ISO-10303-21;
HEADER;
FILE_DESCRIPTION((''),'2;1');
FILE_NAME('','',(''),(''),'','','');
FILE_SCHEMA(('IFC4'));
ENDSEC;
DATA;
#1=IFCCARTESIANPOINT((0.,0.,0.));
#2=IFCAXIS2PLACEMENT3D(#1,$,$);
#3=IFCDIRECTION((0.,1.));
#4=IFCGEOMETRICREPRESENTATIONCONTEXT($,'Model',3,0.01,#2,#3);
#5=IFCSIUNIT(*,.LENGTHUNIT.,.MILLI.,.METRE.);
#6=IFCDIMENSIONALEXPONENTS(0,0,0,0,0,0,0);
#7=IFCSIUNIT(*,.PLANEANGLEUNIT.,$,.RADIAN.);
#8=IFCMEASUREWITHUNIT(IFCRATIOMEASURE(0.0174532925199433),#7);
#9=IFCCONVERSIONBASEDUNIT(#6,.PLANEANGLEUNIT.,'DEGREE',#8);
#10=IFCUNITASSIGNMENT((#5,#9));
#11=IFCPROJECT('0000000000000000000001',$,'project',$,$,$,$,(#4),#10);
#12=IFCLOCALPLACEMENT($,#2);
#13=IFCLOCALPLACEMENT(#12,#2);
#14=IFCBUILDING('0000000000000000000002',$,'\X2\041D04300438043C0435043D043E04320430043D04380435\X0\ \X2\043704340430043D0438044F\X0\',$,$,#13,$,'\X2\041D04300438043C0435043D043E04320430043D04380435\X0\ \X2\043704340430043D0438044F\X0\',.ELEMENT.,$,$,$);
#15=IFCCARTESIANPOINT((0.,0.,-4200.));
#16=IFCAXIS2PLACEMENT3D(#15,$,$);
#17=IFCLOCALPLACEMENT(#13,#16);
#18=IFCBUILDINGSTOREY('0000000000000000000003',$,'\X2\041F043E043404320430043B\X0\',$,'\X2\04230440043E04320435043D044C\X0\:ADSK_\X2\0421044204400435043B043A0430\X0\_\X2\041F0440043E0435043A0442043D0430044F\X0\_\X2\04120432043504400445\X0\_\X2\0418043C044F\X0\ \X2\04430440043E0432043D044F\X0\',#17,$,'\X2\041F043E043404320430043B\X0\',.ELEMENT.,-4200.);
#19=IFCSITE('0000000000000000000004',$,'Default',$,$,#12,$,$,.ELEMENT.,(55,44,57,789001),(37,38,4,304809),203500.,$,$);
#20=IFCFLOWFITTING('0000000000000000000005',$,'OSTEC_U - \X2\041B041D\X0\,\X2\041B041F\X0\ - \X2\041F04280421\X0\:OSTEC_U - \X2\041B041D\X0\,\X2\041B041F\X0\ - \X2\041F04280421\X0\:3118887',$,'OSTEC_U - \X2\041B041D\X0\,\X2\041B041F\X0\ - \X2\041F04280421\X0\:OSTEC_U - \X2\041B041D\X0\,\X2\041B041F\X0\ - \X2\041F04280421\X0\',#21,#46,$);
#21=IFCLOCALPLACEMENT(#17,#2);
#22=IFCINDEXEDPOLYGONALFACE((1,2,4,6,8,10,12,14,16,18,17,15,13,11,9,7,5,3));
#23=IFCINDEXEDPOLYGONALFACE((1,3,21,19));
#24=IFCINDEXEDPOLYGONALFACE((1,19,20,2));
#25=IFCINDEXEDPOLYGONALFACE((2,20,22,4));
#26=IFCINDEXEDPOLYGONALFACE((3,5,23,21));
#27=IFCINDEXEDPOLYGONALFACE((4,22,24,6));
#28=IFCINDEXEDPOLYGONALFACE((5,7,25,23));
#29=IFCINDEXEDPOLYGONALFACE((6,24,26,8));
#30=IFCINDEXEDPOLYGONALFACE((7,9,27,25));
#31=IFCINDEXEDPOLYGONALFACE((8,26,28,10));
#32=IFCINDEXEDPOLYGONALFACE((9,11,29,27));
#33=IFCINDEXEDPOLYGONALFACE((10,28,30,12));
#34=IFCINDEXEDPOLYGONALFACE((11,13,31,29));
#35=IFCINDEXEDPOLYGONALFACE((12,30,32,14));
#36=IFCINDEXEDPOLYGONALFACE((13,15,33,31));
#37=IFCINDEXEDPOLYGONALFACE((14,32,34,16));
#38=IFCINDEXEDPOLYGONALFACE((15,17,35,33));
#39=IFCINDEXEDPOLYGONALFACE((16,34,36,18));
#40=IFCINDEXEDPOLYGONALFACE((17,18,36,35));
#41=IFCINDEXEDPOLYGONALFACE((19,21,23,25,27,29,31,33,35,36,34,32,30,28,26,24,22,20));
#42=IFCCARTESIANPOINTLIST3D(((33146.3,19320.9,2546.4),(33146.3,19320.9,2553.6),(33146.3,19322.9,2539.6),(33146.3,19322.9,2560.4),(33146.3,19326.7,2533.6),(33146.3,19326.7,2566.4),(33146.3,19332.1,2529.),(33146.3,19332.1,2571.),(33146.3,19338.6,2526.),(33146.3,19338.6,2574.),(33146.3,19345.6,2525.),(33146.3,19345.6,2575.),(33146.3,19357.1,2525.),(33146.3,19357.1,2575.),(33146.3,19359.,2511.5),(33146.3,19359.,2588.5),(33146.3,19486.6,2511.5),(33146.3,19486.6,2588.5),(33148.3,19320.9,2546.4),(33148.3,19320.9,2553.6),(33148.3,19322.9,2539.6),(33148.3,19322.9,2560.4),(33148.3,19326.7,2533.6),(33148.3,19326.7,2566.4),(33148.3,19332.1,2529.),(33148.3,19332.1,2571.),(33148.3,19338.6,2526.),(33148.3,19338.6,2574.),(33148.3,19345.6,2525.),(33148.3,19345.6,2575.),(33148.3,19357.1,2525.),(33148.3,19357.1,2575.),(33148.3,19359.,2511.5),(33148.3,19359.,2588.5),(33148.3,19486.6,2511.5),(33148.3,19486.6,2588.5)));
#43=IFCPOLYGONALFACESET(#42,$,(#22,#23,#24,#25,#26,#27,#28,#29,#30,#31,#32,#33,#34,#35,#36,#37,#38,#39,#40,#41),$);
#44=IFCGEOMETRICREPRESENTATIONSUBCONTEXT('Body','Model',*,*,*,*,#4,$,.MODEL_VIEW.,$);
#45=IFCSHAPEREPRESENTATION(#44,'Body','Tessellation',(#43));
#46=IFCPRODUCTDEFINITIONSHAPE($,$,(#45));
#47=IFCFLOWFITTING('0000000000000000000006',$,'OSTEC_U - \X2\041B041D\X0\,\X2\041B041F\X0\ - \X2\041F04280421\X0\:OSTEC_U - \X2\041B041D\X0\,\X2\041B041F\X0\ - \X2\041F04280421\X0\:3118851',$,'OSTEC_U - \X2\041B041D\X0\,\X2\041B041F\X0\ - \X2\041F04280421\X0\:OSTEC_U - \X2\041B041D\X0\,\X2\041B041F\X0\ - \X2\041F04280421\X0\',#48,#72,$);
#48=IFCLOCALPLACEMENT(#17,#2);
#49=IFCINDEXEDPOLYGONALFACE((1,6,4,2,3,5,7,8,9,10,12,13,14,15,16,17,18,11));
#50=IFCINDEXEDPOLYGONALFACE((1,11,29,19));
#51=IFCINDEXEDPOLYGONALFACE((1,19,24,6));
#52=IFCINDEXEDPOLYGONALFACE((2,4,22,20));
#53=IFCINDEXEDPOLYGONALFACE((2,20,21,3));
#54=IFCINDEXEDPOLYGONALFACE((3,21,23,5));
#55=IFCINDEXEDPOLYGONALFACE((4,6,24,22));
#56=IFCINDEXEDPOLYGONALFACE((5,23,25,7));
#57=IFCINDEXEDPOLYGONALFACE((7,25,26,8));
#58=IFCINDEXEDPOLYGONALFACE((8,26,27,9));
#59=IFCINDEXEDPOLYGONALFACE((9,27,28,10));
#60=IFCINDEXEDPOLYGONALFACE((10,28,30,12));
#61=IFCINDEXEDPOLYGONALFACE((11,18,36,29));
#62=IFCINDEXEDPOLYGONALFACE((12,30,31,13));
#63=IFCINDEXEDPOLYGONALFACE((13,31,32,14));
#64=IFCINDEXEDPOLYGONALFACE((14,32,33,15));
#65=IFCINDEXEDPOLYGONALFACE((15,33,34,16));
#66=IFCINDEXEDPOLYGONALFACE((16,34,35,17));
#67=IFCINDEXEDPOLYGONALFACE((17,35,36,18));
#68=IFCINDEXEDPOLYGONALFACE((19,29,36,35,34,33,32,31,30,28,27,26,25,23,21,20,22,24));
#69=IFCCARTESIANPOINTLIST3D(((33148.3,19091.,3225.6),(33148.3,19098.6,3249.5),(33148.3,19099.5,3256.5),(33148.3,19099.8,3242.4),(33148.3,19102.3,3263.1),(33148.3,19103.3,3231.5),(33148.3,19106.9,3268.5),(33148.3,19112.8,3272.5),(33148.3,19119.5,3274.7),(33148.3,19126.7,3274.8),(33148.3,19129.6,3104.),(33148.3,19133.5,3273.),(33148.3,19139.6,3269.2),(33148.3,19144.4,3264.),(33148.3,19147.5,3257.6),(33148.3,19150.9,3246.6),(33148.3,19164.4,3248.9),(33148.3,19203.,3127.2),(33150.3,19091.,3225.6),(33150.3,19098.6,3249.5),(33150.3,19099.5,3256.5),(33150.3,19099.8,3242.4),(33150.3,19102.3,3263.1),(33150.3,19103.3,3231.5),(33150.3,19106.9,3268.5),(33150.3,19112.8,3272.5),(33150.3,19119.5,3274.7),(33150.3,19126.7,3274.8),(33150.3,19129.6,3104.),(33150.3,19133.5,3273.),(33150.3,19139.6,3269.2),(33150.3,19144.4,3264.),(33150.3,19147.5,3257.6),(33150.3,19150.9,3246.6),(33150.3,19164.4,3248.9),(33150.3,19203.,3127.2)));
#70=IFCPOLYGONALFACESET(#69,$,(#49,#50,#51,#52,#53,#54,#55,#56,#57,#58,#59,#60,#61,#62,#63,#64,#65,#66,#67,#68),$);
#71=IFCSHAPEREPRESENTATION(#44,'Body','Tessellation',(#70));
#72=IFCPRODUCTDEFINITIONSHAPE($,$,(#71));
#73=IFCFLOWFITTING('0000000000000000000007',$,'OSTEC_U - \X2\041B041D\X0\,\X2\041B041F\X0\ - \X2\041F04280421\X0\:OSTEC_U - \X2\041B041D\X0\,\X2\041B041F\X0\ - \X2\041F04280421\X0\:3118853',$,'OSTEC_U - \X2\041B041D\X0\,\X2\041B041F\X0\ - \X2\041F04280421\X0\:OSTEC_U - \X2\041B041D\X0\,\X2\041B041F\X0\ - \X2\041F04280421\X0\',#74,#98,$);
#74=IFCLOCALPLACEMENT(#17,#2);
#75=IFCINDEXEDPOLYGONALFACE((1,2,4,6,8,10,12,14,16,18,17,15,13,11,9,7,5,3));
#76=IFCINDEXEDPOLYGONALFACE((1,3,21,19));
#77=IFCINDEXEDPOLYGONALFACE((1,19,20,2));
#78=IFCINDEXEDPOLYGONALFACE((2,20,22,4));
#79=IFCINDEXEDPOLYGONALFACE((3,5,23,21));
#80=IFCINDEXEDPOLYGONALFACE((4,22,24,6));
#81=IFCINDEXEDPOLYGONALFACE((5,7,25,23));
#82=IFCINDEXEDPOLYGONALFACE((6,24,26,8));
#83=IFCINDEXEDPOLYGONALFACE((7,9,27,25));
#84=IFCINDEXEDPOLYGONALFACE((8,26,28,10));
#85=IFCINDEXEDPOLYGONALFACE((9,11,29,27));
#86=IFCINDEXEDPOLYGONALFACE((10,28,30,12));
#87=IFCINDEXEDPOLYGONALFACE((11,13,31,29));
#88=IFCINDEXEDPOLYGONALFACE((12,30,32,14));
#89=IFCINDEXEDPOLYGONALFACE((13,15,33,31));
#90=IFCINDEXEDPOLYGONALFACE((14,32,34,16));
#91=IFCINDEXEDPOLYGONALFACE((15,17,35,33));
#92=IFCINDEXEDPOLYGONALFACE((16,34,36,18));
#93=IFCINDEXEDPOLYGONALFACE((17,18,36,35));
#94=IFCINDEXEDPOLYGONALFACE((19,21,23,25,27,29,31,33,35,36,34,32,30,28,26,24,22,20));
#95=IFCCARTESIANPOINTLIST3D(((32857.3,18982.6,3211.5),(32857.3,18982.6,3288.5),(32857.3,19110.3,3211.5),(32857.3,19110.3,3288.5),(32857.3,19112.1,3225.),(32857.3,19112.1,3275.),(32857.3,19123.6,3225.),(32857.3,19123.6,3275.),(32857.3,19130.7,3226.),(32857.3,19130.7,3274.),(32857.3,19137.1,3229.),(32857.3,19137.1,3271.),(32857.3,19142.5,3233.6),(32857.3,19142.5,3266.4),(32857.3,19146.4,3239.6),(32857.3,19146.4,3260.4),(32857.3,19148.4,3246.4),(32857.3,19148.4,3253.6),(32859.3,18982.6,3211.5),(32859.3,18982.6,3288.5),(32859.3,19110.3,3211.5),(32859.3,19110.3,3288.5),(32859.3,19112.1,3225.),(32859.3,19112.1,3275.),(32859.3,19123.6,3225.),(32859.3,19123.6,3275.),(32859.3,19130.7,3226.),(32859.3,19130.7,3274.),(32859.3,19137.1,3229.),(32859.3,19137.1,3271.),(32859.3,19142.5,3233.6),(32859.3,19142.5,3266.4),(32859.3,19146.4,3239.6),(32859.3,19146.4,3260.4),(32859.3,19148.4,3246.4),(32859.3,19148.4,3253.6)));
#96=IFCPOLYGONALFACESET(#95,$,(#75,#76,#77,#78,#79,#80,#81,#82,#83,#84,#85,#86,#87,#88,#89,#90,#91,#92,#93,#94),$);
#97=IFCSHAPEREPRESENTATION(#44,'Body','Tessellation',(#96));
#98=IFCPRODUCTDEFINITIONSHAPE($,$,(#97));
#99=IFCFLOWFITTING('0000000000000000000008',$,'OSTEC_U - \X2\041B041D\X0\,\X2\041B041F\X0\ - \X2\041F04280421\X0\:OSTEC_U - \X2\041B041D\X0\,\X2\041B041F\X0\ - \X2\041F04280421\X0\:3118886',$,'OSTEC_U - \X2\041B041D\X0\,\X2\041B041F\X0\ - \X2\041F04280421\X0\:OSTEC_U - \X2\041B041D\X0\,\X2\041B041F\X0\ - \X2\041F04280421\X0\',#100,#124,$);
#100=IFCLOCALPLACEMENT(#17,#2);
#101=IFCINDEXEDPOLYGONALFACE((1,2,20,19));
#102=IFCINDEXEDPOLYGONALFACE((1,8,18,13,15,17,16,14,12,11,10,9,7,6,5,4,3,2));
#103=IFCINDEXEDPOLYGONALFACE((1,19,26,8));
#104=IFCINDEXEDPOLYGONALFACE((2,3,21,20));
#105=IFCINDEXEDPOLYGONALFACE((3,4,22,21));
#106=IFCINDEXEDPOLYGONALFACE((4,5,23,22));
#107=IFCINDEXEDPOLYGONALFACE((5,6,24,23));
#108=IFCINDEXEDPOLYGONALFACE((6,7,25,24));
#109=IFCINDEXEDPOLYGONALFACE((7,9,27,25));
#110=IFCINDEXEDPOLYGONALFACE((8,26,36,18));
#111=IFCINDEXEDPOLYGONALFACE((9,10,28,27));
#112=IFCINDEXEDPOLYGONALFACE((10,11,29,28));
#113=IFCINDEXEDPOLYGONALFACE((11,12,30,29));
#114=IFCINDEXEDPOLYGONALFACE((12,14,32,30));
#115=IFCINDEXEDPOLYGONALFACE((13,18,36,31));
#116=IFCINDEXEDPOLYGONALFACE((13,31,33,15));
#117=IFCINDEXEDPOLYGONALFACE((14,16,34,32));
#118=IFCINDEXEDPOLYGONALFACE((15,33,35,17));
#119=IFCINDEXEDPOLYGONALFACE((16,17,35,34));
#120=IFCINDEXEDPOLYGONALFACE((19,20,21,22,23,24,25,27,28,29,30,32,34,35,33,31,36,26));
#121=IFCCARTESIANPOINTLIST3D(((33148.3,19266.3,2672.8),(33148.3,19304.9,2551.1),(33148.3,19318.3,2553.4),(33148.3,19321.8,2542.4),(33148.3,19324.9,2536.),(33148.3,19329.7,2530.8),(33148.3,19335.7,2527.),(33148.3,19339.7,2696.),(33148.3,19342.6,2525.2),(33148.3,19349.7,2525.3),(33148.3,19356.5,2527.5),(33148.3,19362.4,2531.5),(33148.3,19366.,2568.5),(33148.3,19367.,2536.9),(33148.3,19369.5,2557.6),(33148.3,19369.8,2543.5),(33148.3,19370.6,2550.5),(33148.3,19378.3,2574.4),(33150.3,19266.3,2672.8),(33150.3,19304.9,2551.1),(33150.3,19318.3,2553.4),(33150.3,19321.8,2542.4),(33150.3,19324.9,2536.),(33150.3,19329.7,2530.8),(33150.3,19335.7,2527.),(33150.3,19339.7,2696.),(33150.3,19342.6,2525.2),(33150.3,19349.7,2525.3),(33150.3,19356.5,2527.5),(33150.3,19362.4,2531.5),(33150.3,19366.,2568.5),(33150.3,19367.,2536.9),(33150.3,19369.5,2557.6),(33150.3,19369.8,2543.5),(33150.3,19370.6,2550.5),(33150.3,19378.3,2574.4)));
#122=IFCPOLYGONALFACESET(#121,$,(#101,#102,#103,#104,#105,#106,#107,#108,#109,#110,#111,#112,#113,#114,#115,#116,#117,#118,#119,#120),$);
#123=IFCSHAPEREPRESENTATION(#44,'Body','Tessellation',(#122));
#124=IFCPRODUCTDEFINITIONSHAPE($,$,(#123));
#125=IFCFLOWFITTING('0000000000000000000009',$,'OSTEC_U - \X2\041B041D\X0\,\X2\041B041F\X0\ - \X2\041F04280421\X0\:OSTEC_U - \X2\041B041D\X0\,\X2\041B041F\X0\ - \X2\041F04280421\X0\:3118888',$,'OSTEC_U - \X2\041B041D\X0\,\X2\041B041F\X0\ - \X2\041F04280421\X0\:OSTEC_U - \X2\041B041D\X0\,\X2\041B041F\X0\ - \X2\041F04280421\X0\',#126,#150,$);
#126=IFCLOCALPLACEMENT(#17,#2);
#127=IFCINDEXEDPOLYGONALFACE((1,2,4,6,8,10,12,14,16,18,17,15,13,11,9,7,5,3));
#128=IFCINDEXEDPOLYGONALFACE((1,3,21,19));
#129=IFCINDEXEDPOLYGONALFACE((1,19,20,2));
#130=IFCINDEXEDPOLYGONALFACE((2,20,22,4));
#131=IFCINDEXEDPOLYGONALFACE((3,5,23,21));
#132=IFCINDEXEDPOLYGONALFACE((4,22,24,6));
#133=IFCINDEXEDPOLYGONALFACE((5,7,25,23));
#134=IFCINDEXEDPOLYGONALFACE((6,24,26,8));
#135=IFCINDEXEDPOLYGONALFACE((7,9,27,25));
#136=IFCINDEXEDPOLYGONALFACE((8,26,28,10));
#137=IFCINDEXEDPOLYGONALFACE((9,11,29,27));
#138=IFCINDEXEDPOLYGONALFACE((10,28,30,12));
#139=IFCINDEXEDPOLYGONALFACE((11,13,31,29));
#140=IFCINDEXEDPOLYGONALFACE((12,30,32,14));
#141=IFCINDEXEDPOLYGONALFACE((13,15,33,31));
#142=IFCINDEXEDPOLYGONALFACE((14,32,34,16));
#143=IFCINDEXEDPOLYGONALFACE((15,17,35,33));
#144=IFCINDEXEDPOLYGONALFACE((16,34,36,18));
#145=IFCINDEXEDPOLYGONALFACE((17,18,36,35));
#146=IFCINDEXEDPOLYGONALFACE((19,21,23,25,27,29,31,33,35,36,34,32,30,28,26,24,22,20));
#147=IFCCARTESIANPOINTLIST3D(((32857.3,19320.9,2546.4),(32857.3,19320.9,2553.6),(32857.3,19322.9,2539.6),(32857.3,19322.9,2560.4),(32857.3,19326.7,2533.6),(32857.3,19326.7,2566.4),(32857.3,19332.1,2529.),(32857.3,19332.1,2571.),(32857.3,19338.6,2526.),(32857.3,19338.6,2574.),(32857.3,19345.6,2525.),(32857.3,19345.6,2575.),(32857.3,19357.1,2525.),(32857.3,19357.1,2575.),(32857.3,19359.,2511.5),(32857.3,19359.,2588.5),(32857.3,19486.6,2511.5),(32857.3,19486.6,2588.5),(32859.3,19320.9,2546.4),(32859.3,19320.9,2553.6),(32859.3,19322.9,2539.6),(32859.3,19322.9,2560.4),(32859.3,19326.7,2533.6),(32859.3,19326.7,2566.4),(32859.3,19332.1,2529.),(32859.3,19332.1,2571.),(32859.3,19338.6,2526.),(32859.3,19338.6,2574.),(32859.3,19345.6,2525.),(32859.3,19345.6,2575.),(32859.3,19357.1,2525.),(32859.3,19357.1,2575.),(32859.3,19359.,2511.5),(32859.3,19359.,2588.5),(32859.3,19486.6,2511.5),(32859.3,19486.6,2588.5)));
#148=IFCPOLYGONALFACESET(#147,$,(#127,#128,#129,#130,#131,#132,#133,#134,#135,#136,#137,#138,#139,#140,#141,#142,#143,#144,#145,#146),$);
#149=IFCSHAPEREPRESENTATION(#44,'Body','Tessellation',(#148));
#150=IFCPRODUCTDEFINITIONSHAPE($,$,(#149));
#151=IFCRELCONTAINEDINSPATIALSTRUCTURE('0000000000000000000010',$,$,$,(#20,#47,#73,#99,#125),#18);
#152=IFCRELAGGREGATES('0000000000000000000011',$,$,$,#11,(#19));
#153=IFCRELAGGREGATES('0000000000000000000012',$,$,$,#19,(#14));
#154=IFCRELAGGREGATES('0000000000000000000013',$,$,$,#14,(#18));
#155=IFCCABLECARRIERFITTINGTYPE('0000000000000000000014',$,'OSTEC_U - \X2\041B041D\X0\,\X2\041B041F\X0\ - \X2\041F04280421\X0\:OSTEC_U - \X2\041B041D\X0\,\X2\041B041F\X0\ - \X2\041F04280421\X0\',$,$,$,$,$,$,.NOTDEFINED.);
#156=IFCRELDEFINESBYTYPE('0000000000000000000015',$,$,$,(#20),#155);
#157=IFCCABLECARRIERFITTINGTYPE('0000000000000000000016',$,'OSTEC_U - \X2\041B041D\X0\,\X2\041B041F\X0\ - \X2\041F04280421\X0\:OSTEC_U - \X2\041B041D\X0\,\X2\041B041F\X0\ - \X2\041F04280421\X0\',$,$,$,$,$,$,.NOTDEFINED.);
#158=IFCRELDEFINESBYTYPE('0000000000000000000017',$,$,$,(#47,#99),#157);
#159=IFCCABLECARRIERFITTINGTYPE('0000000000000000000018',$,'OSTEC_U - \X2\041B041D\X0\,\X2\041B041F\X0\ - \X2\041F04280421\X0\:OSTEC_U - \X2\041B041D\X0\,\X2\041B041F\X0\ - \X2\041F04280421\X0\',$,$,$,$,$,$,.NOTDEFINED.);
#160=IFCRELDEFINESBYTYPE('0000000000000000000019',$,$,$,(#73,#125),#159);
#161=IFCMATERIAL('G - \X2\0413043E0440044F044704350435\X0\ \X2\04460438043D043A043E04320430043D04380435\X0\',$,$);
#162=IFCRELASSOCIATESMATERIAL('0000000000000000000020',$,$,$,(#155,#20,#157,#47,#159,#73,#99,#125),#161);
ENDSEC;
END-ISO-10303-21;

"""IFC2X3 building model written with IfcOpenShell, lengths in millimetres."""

from ifc_helpers import new_model, entity, si_unit, converted_unit, direction, frame, frame_2d, origin, place, context, subcontext, project, spatial, polyline, circle_curve, parameter, trimmed, segment, composite_curve, outline, extrude, source, transform, mapped, material, type_object, type_shapes, element, save


model = new_model("IFC2X3")

# Units and contexts
model_context = context("Model", 3, precision=0.01, world=origin(), true_north=direction((0.0, 1.0)))
body_context = subcontext(model_context, "Body", "Model", "MODEL_VIEW")
ifc_project = project(units=[si_unit("LENGTHUNIT", "METRE", prefix="MILLI"), converted_unit("PLANEANGLEUNIT", "DEGREE", entity("IfcRatioMeasure", 0.0174532925199433), si_unit("PLANEANGLEUNIT", "RADIAN"), dimensions=[0, 0, 0, 0, 0, 0, 0])], contexts=[model_context])

# Site, building, storey
site_placement = place(None, origin())
site = spatial("IfcSite", under=ifc_project, at=site_placement, Name="Default", CompositionType="ELEMENT", RefLatitude=(55, 44, 57, 789001), RefLongitude=(37, 38, 4, 304809), RefElevation=203500.0)
building_placement = place(site_placement, origin())
building = spatial("IfcBuilding", under=site, at=building_placement, Name="Наименование здания", LongName="Наименование здания", CompositionType="ELEMENT")
storey_placement = place(building_placement, frame((0.0, 0.0, -4200.0)))
storey = spatial("IfcBuildingStorey", under=building, at=storey_placement, Name="Подвал", ObjectType="Уровень:ADSK_Стрелка_Проектная_Вверх_Имя уровня", LongName="Подвал", CompositionType="ELEMENT", Elevation=-4200.0)

# Flow fittings
ifc_material_1 = material(Name="G - Горячее цинкование")
shared_shape_1 = source(origin(), body_context, "Body", "SweptSolid", [
    extrude(outline(composite_curve([segment(trimmed(circle_curve(frame_2d((-41.5, 0.0), x_axis=(1.0, 0.0)), 25.0), [parameter(90.0)], [parameter(270.0)], True, "PARAMETER"), True, "CONTINUOUS"), segment(polyline([(-41.5, -25.0), (-30.0, -25.0)]), True, "CONTINUOUS"), segment(polyline([(-30.0, -25.0), (-28.1, -38.5)]), True, "CONTINUOUS"), segment(polyline([(-28.1, -38.5), (99.5, -38.5)]), True, "CONTINUOUS"), segment(polyline([(99.5, -38.5), (99.5, 38.5)]), True, "CONTINUOUS"), segment(polyline([(99.5, 38.5), (-28.1, 38.5)]), True, "CONTINUOUS"), segment(polyline([(-28.1, 38.5), (-30.0, 25.0)]), True, "CONTINUOUS"), segment(polyline([(-30.0, 25.0), (-41.5, 25.0)]), True, "CONTINUOUS")], self_intersect=False)), frame((41.5, 0.0, 0.0), z_axis=(0.0, 0.0, -1.0), x_axis=(1.0, 0.0, 0.0)), (0.0, 0.0, -1.0), 2.0),
])
cable_carrier_fitting_type_1 = type_object("IfcCableCarrierFittingType", Name="OSTEC_U - ЛН,ЛП - ПШС:OSTEC_U - ЛН,ЛП - ПШС", PredefinedType="NOTDEFINED", material=ifc_material_1)
type_shapes(cable_carrier_fitting_type_1, [shared_shape_1])
flow_fitting_1_placement = place(storey_placement, frame((33146.3, 19345.6, 2550.0), z_axis=(1.0, 0.0, 0.0), x_axis=(0.0, 1.0, 0.0)))
element("IfcFlowFitting", 1, at=flow_fitting_1_placement, inside=storey, type_object=cable_carrier_fitting_type_1, material=ifc_material_1, Name="OSTEC_U - ЛН,ЛП - ПШС:OSTEC_U - ЛН,ЛП - ПШС:3118887", ObjectType="OSTEC_U - ЛН,ЛП - ПШС:OSTEC_U - ЛН,ЛП - ПШС", context=body_context, shape_type="MappedRepresentation", body=[
    mapped(shared_shape_1, transform((0.0, 0.0, 0.0), scale=1.0)),
])
cable_carrier_fitting_type_2 = type_object("IfcCableCarrierFittingType", Name="OSTEC_U - ЛН,ЛП - ПШС:OSTEC_U - ЛН,ЛП - ПШС", PredefinedType="NOTDEFINED", material=ifc_material_1)
shared_shape_2 = source(origin(), body_context, "Body", "SweptSolid", [
    extrude(outline(composite_curve([segment(trimmed(circle_curve(frame_2d((-41.5, 0.0), x_axis=(1.0, 0.0)), 25.0), [parameter(90.0)], [parameter(270.0)], True, "PARAMETER"), True, "CONTINUOUS"), segment(polyline([(-41.5, -25.0), (-30.0, -25.0)]), True, "CONTINUOUS"), segment(polyline([(-30.0, -25.0), (-28.1, -38.5)]), True, "CONTINUOUS"), segment(polyline([(-28.1, -38.5), (99.5, -38.5)]), True, "CONTINUOUS"), segment(polyline([(99.5, -38.5), (99.5, 38.5)]), True, "CONTINUOUS"), segment(polyline([(99.5, 38.5), (-28.1, 38.5)]), True, "CONTINUOUS"), segment(polyline([(-28.1, 38.5), (-30.0, 25.0)]), True, "CONTINUOUS"), segment(polyline([(-30.0, 25.0), (-41.5, 25.0)]), True, "CONTINUOUS")], self_intersect=False)), frame((41.5, 0.0, 0.0)), (0.0, 0.0, 1.0), 2.0),
])
type_shapes(cable_carrier_fitting_type_2, [shared_shape_2])
flow_fitting_2_placement = place(storey_placement, frame((33148.3, 19123.6, 3250.0), z_axis=(1.0, 0.0, 0.0), x_axis=(0.0, 0.302323, -0.953205)))
element("IfcFlowFitting", 2, at=flow_fitting_2_placement, inside=storey, type_object=cable_carrier_fitting_type_2, material=ifc_material_1, Name="OSTEC_U - ЛН,ЛП - ПШС:OSTEC_U - ЛН,ЛП - ПШС:3118851", ObjectType="OSTEC_U - ЛН,ЛП - ПШС:OSTEC_U - ЛН,ЛП - ПШС", context=body_context, shape_type="MappedRepresentation", body=[
    mapped(shared_shape_2, transform((0.0, 0.0, 0.0), scale=1.0)),
])
cable_carrier_fitting_type_3 = type_object("IfcCableCarrierFittingType", Name="OSTEC_U - ЛН,ЛП - ПШС:OSTEC_U - ЛН,ЛП - ПШС", PredefinedType="NOTDEFINED", material=ifc_material_1)
type_shapes(cable_carrier_fitting_type_3, [shared_shape_2])
flow_fitting_3_placement = place(storey_placement, frame((32859.3, 19123.6, 3250.0), z_axis=(-1.0, 0.0, 0.0), x_axis=(0.0, -1.0, 0.0)))
element("IfcFlowFitting", 3, at=flow_fitting_3_placement, inside=storey, type_object=cable_carrier_fitting_type_3, material=ifc_material_1, Name="OSTEC_U - ЛН,ЛП - ПШС:OSTEC_U - ЛН,ЛП - ПШС:3118853", ObjectType="OSTEC_U - ЛН,ЛП - ПШС:OSTEC_U - ЛН,ЛП - ПШС", context=body_context, shape_type="MappedRepresentation", body=[
    mapped(shared_shape_2, transform((0.0, 0.0, 0.0), scale=1.0)),
])
flow_fitting_4_placement = place(storey_placement, frame((33148.3, 19345.6, 2550.0), z_axis=(1.0, 0.0, 0.0), x_axis=(0.0, -0.302323, 0.953205)))
element("IfcFlowFitting", 4, at=flow_fitting_4_placement, inside=storey, type_object=cable_carrier_fitting_type_2, material=ifc_material_1, Name="OSTEC_U - ЛН,ЛП - ПШС:OSTEC_U - ЛН,ЛП - ПШС:3118886", ObjectType="OSTEC_U - ЛН,ЛП - ПШС:OSTEC_U - ЛН,ЛП - ПШС", context=body_context, shape_type="MappedRepresentation", body=[
    mapped(shared_shape_2, transform((0.0, 0.0, 0.0), scale=1.0)),
])
flow_fitting_5_placement = place(storey_placement, frame((32859.3, 19345.6, 2550.0), z_axis=(-1.0, 0.0, 0.0), x_axis=(0.0, 1.0, 0.0)))
element("IfcFlowFitting", 5, at=flow_fitting_5_placement, inside=storey, type_object=cable_carrier_fitting_type_3, material=ifc_material_1, Name="OSTEC_U - ЛН,ЛП - ПШС:OSTEC_U - ЛН,ЛП - ПШС:3118888", ObjectType="OSTEC_U - ЛН,ЛП - ПШС:OSTEC_U - ЛН,ЛП - ПШС", context=body_context, shape_type="MappedRepresentation", body=[
    mapped(shared_shape_2, transform((0.0, 0.0, 0.0), scale=1.0)),
])

save(model, "model.ifc")
